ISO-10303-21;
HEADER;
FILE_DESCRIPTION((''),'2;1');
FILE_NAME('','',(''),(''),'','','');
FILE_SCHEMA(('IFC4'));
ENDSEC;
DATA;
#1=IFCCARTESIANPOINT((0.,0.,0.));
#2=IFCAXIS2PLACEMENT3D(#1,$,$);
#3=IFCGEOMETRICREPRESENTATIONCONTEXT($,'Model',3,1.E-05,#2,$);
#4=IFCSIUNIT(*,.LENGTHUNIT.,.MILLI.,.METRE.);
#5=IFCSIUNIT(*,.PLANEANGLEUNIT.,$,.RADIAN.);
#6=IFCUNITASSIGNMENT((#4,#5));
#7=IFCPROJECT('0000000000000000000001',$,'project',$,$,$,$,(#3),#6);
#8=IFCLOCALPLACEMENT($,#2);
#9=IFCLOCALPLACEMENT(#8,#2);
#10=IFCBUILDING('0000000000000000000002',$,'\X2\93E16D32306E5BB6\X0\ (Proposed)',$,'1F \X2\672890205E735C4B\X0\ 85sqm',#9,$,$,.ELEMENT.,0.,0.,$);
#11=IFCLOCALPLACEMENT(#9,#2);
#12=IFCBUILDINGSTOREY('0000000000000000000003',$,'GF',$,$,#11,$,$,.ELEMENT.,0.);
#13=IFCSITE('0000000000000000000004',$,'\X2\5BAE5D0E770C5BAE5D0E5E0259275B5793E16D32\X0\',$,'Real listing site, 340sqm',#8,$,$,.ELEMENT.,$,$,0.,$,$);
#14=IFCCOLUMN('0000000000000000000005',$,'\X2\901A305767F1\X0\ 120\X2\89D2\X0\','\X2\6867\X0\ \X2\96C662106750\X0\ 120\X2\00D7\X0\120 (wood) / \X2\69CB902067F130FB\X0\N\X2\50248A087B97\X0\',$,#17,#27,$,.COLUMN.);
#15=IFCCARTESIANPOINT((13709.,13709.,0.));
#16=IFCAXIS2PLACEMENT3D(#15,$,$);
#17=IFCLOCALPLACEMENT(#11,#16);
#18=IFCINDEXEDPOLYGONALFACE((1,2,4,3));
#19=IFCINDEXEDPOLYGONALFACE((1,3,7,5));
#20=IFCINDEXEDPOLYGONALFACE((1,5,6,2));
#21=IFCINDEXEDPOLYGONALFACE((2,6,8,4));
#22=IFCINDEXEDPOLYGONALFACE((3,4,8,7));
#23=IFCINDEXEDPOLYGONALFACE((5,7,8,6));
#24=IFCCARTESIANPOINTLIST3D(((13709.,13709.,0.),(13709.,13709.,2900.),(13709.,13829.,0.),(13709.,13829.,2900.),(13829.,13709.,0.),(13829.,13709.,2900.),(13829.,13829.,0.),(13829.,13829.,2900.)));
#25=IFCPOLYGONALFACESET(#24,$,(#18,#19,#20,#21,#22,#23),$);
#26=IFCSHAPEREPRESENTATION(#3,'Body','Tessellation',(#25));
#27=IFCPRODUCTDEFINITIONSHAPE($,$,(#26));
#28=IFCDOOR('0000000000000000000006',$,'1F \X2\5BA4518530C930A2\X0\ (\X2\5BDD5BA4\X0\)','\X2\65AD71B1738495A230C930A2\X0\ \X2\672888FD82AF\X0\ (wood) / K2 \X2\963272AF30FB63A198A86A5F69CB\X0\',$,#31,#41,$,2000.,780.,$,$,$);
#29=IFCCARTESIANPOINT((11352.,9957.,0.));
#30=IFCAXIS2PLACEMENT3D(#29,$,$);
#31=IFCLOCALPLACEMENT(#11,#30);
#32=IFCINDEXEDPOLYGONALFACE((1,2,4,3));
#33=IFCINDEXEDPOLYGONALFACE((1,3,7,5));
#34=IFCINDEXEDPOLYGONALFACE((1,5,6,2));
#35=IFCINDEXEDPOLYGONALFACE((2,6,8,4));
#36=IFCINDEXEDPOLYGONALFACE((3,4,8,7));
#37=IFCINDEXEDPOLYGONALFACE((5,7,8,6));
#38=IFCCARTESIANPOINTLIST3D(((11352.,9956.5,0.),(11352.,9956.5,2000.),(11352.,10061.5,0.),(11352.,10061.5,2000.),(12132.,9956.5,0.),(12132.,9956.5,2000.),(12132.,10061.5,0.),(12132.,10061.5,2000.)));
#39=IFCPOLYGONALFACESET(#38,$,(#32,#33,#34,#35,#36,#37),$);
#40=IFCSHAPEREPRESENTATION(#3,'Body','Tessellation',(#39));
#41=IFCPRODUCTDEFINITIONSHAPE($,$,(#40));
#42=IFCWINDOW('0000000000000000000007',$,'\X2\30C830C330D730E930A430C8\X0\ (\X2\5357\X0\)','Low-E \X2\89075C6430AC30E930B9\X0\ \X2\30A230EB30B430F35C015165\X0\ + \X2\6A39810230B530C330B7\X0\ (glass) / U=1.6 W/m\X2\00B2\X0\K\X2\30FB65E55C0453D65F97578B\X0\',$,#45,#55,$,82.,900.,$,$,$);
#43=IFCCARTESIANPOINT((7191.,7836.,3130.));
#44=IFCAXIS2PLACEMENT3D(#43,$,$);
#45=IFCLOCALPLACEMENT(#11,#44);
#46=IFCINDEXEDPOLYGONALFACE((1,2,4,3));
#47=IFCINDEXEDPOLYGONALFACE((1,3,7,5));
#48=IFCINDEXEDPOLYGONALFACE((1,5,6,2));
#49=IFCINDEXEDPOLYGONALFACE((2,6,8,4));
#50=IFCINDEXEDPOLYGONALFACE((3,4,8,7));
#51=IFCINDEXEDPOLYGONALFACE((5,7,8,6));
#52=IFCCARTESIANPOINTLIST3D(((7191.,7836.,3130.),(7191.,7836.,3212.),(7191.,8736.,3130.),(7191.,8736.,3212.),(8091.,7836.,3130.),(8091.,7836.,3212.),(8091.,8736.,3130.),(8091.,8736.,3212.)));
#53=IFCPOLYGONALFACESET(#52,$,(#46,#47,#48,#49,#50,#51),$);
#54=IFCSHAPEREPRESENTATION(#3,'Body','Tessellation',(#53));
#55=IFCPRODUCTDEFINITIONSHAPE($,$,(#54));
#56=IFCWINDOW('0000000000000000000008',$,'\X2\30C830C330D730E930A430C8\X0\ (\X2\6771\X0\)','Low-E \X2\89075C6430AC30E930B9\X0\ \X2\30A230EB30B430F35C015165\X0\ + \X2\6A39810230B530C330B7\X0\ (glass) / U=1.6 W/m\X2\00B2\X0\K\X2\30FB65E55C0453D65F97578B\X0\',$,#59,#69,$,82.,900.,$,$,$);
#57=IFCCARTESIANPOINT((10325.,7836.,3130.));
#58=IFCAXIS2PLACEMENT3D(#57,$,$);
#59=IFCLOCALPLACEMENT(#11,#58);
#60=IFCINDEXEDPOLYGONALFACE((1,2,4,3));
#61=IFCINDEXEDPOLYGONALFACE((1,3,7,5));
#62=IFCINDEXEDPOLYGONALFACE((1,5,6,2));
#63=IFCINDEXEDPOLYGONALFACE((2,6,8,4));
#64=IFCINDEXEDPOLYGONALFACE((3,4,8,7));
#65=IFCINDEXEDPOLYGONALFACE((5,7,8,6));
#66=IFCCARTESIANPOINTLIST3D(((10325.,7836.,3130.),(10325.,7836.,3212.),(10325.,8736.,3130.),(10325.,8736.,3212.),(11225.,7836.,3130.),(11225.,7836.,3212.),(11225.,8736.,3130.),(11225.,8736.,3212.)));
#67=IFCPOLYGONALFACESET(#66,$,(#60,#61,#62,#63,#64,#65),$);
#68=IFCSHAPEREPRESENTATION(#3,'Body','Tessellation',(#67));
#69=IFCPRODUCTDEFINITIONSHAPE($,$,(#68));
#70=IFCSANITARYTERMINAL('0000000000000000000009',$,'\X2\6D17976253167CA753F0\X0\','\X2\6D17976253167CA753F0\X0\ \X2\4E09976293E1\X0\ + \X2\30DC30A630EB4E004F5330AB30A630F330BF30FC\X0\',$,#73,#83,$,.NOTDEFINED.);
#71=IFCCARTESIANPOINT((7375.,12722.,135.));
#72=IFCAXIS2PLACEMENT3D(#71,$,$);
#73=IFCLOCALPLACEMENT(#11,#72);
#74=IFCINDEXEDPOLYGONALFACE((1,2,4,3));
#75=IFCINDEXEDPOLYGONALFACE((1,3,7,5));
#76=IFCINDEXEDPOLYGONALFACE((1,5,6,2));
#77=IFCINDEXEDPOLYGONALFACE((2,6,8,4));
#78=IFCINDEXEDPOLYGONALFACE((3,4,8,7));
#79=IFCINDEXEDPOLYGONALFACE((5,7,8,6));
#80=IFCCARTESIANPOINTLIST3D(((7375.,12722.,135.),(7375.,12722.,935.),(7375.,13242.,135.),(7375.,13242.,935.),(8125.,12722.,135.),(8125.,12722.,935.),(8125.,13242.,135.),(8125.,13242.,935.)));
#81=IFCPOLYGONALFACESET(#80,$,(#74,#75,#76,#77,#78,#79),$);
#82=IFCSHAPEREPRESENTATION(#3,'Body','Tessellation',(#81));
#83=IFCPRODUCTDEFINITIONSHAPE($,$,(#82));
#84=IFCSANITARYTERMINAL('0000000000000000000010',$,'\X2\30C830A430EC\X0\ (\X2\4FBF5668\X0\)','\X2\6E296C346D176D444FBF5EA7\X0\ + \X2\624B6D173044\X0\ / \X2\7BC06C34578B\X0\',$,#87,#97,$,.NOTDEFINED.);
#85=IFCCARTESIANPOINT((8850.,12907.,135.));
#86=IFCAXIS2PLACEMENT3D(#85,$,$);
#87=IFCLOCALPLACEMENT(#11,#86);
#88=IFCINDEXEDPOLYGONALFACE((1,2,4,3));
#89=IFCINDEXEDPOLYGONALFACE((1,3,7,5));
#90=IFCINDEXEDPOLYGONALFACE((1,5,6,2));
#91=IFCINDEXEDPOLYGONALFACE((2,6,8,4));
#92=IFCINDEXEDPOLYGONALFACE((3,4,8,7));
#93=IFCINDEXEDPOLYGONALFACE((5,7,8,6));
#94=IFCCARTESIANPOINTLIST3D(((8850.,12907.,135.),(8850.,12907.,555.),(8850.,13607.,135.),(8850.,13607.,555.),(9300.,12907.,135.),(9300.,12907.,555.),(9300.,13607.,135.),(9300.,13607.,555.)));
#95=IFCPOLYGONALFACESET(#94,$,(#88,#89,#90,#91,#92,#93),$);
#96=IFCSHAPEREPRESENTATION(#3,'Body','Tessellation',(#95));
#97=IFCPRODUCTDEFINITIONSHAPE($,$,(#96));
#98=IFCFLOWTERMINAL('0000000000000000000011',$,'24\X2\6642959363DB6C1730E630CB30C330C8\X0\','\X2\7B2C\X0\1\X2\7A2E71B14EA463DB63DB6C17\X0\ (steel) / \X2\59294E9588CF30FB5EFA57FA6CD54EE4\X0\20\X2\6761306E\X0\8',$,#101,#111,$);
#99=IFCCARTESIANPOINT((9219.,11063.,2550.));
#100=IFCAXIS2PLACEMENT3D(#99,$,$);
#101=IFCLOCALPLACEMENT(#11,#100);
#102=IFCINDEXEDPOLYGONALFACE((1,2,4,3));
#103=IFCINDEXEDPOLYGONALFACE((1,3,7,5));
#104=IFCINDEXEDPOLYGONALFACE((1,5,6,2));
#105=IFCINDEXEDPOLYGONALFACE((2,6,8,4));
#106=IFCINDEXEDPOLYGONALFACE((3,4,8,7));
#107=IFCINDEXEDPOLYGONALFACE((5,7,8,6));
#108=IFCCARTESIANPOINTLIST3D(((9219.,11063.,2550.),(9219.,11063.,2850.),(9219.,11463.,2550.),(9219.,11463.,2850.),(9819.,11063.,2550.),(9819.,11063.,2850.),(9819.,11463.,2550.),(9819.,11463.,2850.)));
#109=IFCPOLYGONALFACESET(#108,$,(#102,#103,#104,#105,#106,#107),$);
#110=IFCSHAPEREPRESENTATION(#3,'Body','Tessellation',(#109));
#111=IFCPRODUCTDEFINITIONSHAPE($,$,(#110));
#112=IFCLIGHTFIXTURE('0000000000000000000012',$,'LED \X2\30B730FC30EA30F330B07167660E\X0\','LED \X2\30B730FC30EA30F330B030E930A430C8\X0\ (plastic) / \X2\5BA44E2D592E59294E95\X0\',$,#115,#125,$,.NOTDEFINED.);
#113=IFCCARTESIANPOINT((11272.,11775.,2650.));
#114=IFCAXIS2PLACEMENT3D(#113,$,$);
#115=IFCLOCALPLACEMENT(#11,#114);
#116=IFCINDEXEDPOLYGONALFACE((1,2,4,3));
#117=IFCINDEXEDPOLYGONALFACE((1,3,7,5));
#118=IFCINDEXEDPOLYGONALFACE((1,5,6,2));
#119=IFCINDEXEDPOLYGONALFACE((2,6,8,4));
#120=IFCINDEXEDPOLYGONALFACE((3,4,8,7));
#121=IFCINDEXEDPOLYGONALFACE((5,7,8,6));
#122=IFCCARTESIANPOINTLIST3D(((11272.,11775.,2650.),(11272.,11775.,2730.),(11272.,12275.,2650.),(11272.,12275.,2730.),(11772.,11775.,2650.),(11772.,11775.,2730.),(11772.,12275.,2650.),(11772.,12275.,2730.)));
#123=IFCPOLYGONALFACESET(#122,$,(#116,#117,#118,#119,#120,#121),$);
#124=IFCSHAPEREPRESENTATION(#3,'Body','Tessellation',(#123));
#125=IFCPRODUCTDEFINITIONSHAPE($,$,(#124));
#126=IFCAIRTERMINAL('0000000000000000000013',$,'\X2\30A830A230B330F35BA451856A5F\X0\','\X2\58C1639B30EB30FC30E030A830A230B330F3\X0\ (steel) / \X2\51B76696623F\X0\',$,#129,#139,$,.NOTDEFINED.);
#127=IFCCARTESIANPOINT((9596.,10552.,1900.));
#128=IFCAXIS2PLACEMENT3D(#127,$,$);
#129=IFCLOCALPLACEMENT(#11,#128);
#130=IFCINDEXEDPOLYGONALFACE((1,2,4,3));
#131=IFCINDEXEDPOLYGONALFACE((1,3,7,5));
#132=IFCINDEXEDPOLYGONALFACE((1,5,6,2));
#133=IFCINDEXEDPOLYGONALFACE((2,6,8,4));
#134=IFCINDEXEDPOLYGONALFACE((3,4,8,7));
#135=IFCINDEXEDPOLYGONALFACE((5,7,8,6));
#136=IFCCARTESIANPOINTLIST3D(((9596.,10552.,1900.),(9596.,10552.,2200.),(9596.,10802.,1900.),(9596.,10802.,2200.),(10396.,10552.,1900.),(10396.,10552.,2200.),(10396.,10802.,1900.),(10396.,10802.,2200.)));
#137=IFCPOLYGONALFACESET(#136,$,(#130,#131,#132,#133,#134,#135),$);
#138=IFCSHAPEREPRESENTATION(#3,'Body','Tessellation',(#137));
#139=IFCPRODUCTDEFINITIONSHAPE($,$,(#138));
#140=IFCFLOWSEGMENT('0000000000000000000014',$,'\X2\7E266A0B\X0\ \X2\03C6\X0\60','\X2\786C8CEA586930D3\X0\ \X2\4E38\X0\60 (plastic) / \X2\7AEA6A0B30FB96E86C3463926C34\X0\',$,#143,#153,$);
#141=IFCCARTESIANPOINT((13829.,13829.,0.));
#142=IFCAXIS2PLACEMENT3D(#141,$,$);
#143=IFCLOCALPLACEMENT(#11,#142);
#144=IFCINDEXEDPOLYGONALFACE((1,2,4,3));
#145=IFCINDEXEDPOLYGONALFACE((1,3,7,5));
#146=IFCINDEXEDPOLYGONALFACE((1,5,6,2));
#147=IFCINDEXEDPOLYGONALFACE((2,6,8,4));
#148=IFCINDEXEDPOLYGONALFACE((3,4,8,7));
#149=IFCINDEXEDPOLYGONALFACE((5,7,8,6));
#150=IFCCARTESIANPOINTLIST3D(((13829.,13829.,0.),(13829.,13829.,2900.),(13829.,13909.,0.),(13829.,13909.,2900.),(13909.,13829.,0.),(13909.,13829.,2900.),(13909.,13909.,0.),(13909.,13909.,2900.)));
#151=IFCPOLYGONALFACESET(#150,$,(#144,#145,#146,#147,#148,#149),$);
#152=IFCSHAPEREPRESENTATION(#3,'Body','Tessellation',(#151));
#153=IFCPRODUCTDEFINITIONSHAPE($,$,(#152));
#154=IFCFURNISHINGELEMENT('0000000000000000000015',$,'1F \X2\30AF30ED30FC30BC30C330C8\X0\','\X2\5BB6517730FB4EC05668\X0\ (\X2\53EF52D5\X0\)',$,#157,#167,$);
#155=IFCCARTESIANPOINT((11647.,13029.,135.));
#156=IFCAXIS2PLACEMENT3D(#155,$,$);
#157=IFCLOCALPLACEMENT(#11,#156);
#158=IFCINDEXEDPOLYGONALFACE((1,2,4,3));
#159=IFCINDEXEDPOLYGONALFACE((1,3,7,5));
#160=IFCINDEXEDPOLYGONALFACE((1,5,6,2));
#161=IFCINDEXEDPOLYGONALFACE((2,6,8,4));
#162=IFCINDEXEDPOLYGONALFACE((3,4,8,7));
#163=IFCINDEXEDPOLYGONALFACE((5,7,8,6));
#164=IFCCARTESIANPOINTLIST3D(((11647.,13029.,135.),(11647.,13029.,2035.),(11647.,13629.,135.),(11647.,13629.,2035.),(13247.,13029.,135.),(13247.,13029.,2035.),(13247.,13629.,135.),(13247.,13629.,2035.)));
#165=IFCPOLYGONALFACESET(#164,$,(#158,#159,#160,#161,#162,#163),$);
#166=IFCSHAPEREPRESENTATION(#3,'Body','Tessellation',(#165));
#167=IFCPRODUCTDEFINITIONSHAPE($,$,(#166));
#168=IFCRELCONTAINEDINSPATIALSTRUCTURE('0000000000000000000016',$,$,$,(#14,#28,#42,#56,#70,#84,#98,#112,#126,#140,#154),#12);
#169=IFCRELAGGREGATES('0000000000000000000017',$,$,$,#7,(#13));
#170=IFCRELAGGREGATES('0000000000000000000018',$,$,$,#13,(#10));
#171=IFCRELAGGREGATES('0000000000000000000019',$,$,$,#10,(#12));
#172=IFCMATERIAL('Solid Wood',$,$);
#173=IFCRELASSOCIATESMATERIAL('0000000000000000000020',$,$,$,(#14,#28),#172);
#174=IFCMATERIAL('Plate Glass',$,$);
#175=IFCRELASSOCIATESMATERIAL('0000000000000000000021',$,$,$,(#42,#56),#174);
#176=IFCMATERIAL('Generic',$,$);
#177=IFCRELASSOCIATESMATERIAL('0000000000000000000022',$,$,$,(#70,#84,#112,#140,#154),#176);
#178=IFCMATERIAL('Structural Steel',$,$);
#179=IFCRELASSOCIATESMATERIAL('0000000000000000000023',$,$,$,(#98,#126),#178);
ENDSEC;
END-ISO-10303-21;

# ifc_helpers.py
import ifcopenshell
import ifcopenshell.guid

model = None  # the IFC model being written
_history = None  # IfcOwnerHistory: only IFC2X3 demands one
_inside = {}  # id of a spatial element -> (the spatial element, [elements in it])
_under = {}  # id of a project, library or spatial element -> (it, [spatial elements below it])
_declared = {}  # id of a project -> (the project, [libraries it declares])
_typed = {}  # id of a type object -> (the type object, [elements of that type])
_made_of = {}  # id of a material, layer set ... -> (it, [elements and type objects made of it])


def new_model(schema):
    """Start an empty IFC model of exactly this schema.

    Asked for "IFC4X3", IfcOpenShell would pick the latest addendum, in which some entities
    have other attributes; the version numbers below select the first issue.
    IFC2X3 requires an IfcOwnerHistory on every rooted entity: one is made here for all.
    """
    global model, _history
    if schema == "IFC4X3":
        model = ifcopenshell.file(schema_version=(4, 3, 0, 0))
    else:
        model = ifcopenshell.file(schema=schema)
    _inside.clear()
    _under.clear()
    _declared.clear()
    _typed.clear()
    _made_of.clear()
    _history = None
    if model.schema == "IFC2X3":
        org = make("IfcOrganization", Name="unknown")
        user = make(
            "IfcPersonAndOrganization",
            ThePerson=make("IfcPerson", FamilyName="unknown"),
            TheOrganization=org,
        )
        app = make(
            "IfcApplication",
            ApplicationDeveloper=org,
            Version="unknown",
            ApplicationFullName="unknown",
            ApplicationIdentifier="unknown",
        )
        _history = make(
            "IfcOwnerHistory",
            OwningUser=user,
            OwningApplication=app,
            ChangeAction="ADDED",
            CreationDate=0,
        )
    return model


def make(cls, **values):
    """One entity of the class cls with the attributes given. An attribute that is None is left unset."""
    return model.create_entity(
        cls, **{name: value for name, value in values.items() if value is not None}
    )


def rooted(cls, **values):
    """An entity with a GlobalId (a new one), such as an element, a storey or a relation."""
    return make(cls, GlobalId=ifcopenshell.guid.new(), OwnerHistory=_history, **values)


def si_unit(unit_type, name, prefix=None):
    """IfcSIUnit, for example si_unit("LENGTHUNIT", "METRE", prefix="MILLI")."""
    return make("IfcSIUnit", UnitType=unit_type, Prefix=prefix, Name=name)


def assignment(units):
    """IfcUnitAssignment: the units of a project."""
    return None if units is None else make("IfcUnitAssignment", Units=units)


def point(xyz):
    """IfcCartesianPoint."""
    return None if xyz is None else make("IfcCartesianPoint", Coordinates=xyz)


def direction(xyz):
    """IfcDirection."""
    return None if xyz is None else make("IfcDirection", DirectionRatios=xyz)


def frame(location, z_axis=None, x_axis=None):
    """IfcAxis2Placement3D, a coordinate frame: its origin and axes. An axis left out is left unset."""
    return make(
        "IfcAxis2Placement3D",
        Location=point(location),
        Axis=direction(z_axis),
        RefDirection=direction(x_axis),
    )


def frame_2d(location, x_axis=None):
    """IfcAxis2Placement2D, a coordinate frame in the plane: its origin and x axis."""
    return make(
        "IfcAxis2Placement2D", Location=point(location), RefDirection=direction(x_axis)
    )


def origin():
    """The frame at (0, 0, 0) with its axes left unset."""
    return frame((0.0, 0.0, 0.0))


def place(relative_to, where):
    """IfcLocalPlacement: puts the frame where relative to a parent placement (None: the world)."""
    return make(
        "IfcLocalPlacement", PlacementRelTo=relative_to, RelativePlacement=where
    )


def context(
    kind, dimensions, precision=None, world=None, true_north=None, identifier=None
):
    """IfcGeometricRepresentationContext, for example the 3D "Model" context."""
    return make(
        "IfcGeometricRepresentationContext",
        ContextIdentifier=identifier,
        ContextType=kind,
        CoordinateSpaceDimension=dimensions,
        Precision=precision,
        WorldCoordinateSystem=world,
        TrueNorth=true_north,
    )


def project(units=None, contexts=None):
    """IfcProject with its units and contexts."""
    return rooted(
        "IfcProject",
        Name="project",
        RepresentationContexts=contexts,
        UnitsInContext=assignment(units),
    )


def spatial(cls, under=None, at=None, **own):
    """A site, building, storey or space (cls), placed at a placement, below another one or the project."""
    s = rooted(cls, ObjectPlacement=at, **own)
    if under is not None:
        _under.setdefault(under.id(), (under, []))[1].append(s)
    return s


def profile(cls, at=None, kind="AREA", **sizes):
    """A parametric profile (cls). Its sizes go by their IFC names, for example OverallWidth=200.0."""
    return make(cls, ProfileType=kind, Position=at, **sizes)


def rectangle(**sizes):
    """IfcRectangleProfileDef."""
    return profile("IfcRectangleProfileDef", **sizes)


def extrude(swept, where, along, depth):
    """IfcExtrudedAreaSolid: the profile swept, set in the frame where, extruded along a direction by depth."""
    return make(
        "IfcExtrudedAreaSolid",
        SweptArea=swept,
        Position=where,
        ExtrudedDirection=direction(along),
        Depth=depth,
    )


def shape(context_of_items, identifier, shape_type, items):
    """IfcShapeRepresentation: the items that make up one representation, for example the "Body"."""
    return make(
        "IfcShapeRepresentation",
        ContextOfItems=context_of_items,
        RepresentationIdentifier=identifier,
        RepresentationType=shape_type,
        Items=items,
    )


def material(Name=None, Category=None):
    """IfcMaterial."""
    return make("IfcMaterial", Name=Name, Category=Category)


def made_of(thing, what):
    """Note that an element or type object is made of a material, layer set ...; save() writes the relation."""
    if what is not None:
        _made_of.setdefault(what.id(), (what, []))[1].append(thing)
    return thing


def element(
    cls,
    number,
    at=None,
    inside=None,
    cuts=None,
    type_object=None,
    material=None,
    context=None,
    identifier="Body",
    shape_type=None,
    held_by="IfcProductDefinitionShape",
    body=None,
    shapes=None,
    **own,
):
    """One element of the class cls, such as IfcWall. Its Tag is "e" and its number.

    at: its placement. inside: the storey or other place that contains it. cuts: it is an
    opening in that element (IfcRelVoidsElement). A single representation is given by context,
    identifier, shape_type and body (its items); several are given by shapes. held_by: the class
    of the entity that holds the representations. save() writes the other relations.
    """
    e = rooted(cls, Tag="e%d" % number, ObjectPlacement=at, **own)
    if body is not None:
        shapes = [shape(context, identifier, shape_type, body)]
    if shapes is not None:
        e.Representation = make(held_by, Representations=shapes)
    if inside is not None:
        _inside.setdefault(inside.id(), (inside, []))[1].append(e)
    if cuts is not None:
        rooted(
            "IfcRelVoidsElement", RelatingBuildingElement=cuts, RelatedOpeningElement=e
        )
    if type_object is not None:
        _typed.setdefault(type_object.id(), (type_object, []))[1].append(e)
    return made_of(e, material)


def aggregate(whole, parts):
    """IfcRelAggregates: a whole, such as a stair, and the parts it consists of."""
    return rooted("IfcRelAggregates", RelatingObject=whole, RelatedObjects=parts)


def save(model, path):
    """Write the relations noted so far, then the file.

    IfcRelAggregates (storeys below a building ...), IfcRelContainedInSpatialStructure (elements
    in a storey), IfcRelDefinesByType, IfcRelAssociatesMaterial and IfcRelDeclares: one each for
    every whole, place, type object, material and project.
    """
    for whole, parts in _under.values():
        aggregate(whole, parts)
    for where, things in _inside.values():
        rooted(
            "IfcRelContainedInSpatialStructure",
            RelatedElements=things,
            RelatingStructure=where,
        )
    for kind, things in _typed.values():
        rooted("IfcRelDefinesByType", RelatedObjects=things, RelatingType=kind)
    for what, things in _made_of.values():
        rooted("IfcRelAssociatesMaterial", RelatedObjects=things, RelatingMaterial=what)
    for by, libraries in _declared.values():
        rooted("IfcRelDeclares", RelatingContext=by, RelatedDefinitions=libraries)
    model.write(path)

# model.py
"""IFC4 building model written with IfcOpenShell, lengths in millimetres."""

from ifc_helpers import new_model, si_unit, frame, frame_2d, origin, place, context, project, spatial, rectangle, extrude, material, element, save


model = new_model("IFC4")

# Units and contexts
model_context = context("Model", 3, precision=1e-05, world=origin())
ifc_project = project(units=[si_unit("LENGTHUNIT", "METRE", prefix="MILLI"), si_unit("PLANEANGLEUNIT", "RADIAN")], contexts=[model_context])

# Site, building, storey
site_placement = place(None, origin())
site = spatial("IfcSite", under=ifc_project, at=site_placement, Name="宮崎県宮崎市大字鏡洲", ObjectType="Real listing site, 340sqm", CompositionType="ELEMENT", RefElevation=0.0)
building_placement = place(site_placement, origin())
building = spatial("IfcBuilding", under=site, at=building_placement, Name="鏡洲の家 (Proposed)", ObjectType="1F 木造平屋 85sqm", CompositionType="ELEMENT", ElevationOfRefHeight=0.0, ElevationOfTerrain=0.0)
storey_placement = place(building_placement, origin())
storey = spatial("IfcBuildingStorey", under=building, at=storey_placement, Name="GF", CompositionType="ELEMENT", Elevation=0.0)

# Column
ifc_material_1 = material(Name="Solid Wood")
column_1_placement = place(storey_placement, frame((13709.0, 13709.0, 0.0)))
element("IfcColumn", 1, at=column_1_placement, inside=storey, material=ifc_material_1, Name="通し柱 120角", Description="桧 集成材 120×120 (wood) / 構造柱・N値計算", PredefinedType="COLUMN", context=model_context, shape_type="SweptSolid", body=[
    extrude(rectangle(XDim=120.0, YDim=120.0, at=frame_2d((60.0, 60.0))), frame((13709.0, 13709.0, 0.0)), (0.0, 0.0, 1.0), 2900.0),
])

# Door
door_placement = place(storey_placement, frame((11352.0, 9957.0, 0.0)))
element("IfcDoor", 2, at=door_placement, inside=storey, material=ifc_material_1, Name="1F 室内ドア (寝室)", Description="断熱玄関ドア 木製芯 (wood) / K2 防犯・採風機構", OverallHeight=2000.0, OverallWidth=780.0, context=model_context, shape_type="SweptSolid", body=[
    extrude(rectangle(XDim=780.0, YDim=105.0, at=frame_2d((390.0, 52.0))), frame((11352.0, 9957.0, 0.0)), (0.0, 0.0, 1.0), 2000.0),
])

# Windows
ifc_material_2 = material(Name="Plate Glass")
window_1_placement = place(storey_placement, frame((7191.0, 7836.0, 3130.0)))
element("IfcWindow", 3, at=window_1_placement, inside=storey, material=ifc_material_2, Name="トップライト (南)", Description="Low-E 複層ガラス アルゴン封入 + 樹脂サッシ (glass) / U=1.6 W/m²K・日射取得型", OverallHeight=82.0, OverallWidth=900.0, context=model_context, shape_type="SweptSolid", body=[
    extrude(rectangle(XDim=900.0, YDim=900.0, at=frame_2d((450.0, 450.0))), frame((7191.0, 7836.0, 3130.0)), (0.0, 0.0, 1.0), 82.0),
])
window_2_placement = place(storey_placement, frame((10325.0, 7836.0, 3130.0)))
element("IfcWindow", 4, at=window_2_placement, inside=storey, material=ifc_material_2, Name="トップライト (東)", Description="Low-E 複層ガラス アルゴン封入 + 樹脂サッシ (glass) / U=1.6 W/m²K・日射取得型", OverallHeight=82.0, OverallWidth=900.0, context=model_context, shape_type="SweptSolid", body=[
    extrude(rectangle(XDim=900.0, YDim=900.0, at=frame_2d((450.0, 450.0))), frame((10325.0, 7836.0, 3130.0)), (0.0, 0.0, 1.0), 82.0),
])

# Sanitary terminals
ifc_material_3 = material(Name="Generic")
sanitary_terminal_1_placement = place(storey_placement, frame((7375.0, 12722.0, 135.0)))
element("IfcSanitaryTerminal", 5, at=sanitary_terminal_1_placement, inside=storey, material=ifc_material_3, Name="洗面化粧台", Description="洗面化粧台 三面鏡 + ボウル一体カウンター", PredefinedType="NOTDEFINED", context=model_context, shape_type="SweptSolid", body=[
    extrude(rectangle(XDim=750.0, YDim=520.0, at=frame_2d((375.0, 260.0))), frame((7375.0, 12722.0, 135.0)), (0.0, 0.0, 1.0), 800.0),
])
sanitary_terminal_2_placement = place(storey_placement, frame((8850.0, 12907.0, 135.0)))
element("IfcSanitaryTerminal", 6, at=sanitary_terminal_2_placement, inside=storey, material=ifc_material_3, Name="トイレ (便器)", Description="温水洗浄便座 + 手洗い / 節水型", PredefinedType="NOTDEFINED", context=model_context, shape_type="SweptSolid", body=[
    extrude(rectangle(XDim=450.0, YDim=700.0, at=frame_2d((225.0, 350.0))), frame((8850.0, 12907.0, 135.0)), (0.0, 0.0, 1.0), 420.0),
])

# Flow terminal
ifc_material_4 = material(Name="Structural Steel")
flow_terminal_placement = place(storey_placement, frame((9219.0, 11063.0, 2550.0)))
element("IfcFlowTerminal", 7, at=flow_terminal_placement, inside=storey, material=ifc_material_4, Name="24時間換気ユニット", Description="第1種熱交換換気 (steel) / 天井裏・建基法令20条の8", context=model_context, shape_type="SweptSolid", body=[
    extrude(rectangle(XDim=600.0, YDim=400.0, at=frame_2d((300.0, 200.0))), frame((9219.0, 11063.0, 2550.0)), (0.0, 0.0, 1.0), 300.0),
])

# Light fixture
light_fixture_placement = place(storey_placement, frame((11272.0, 11775.0, 2650.0)))
element("IfcLightFixture", 8, at=light_fixture_placement, inside=storey, material=ifc_material_3, Name="LED シーリング照明", Description="LED シーリングライト (plastic) / 室中央天井", PredefinedType="NOTDEFINED", context=model_context, shape_type="SweptSolid", body=[
    extrude(rectangle(XDim=500.0, YDim=500.0, at=frame_2d((250.0, 250.0))), frame((11272.0, 11775.0, 2650.0)), (0.0, 0.0, 1.0), 80.0),
])

# Air terminal
air_terminal_placement = place(storey_placement, frame((9596.0, 10552.0, 1900.0)))
element("IfcAirTerminal", 9, at=air_terminal_placement, inside=storey, material=ifc_material_4, Name="エアコン室内機", Description="壁掛ルームエアコン (steel) / 冷暖房", PredefinedType="NOTDEFINED", context=model_context, shape_type="SweptSolid", body=[
    extrude(rectangle(XDim=800.0, YDim=250.0, at=frame_2d((400.0, 125.0))), frame((9596.0, 10552.0, 1900.0)), (0.0, 0.0, 1.0), 300.0),
])

# Flow segment
flow_segment_placement = place(storey_placement, frame((13829.0, 13829.0, 0.0)))
element("IfcFlowSegment", 10, at=flow_segment_placement, inside=storey, material=ifc_material_3, Name="縦樋 φ60", Description="硬質塩ビ 丸60 (plastic) / 竪樋・雨水排水", context=model_context, shape_type="SweptSolid", body=[
    extrude(rectangle(XDim=80.0, YDim=80.0, at=frame_2d((40.0, 40.0))), frame((13829.0, 13829.0, 0.0)), (0.0, 0.0, 1.0), 2900.0),
])

# Furnishing element
furnishing_placement = place(storey_placement, frame((11647.0, 13029.0, 135.0)))
element("IfcFurnishingElement", 11, at=furnishing_placement, inside=storey, material=ifc_material_3, Name="1F クローゼット", Description="家具・什器 (可動)", context=model_context, shape_type="SweptSolid", body=[
    extrude(rectangle(XDim=1600.0, YDim=600.0, at=frame_2d((800.0, 300.0))), frame((11647.0, 13029.0, 135.0)), (0.0, 0.0, 1.0), 1900.0),
])

save(model, "model.ifc")
